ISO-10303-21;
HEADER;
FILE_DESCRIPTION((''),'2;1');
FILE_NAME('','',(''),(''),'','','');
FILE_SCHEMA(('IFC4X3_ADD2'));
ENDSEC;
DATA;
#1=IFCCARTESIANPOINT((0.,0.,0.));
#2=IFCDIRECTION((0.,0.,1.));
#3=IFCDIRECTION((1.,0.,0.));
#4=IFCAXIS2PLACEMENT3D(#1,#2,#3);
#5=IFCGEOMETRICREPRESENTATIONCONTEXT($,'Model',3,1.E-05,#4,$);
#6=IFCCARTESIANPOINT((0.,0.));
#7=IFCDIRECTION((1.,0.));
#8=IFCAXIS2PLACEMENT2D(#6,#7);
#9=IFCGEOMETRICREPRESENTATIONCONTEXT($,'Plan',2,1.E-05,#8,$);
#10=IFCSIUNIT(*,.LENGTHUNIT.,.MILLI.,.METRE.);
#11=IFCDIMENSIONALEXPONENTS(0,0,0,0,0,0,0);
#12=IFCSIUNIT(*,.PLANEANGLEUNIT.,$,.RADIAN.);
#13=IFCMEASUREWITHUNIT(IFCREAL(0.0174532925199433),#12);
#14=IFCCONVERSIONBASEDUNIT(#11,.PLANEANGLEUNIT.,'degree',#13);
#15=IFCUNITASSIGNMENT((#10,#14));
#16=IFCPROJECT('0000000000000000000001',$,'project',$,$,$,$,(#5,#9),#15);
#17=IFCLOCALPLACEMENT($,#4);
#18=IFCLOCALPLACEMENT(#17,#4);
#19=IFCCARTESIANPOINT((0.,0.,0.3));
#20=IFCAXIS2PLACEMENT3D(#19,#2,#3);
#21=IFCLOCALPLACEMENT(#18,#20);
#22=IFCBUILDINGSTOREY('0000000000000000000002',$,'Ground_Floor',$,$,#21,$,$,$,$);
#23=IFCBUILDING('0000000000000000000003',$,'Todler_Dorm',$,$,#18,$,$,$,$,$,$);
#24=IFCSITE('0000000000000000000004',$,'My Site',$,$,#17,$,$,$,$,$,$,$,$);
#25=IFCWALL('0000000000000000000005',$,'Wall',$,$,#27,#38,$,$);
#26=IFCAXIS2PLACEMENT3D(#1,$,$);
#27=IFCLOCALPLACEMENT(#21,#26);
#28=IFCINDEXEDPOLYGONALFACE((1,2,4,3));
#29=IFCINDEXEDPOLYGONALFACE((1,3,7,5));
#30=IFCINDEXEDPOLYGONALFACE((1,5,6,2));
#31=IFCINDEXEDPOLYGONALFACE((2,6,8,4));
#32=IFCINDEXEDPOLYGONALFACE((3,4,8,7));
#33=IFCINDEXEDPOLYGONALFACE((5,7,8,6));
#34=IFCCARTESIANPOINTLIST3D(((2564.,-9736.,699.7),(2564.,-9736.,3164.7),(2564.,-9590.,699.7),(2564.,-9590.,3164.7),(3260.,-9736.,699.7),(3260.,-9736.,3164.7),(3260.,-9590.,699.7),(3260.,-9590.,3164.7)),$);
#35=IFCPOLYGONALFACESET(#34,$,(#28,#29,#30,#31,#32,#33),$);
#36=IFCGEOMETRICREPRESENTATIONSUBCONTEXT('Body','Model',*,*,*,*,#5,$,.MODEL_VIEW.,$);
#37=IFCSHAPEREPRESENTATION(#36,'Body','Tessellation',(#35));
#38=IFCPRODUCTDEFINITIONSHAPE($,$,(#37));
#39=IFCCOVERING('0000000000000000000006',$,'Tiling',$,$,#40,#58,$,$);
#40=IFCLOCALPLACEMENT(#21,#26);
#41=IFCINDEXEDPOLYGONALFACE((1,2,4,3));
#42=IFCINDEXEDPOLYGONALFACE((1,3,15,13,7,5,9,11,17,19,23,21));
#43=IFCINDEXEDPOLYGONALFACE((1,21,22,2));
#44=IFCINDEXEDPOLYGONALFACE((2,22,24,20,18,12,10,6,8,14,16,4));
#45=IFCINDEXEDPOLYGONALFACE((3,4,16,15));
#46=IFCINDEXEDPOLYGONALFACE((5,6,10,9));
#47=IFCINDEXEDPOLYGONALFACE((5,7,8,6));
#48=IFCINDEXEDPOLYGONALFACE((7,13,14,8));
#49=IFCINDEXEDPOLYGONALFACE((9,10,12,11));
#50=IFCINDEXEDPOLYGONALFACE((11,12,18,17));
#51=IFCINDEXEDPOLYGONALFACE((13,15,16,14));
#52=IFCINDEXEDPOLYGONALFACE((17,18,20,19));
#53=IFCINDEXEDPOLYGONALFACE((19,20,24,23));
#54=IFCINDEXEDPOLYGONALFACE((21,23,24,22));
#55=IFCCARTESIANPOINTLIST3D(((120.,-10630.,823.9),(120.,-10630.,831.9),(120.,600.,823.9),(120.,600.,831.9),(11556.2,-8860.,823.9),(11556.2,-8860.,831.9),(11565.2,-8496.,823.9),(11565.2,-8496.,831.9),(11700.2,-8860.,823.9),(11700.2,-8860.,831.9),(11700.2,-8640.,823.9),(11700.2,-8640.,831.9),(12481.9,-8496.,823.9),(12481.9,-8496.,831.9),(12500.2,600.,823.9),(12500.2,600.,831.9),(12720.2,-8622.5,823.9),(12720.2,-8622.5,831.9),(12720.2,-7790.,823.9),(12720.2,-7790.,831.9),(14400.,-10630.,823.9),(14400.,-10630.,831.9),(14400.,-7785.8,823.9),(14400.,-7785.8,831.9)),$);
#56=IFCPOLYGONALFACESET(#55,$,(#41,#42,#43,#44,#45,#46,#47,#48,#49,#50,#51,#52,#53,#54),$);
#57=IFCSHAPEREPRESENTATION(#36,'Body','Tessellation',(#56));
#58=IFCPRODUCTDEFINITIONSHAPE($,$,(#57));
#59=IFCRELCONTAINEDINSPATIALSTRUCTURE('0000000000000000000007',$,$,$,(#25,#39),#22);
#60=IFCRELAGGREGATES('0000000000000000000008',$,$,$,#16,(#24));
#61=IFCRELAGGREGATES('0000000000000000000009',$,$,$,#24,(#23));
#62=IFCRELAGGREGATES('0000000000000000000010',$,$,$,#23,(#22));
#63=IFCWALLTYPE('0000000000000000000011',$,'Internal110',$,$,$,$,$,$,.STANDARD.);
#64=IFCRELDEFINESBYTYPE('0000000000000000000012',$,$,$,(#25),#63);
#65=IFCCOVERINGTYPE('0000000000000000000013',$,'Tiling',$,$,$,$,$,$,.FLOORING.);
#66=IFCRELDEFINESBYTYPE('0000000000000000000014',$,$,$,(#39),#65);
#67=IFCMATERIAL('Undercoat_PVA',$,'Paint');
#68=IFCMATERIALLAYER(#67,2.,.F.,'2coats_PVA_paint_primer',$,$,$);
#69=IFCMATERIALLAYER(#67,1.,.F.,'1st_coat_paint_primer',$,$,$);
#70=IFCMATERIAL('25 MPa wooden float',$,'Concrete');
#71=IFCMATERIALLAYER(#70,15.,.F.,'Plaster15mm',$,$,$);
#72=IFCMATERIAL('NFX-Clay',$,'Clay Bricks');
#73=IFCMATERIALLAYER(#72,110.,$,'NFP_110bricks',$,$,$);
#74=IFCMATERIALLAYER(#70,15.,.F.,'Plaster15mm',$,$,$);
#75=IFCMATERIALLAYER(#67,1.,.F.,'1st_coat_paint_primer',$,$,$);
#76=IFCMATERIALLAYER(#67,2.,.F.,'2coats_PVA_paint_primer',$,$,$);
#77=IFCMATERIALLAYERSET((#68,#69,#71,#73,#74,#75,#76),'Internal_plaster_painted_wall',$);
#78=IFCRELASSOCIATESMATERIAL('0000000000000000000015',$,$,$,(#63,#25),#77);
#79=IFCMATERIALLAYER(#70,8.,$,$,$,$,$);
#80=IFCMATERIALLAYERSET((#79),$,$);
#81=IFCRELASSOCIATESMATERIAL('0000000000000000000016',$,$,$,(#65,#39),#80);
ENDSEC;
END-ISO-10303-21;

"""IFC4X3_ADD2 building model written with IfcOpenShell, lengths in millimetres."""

from ifc_helpers import new_model, entity, si_unit, converted_unit, frame, origin_with_axes, origin_2d_with_axis, place, context, subcontext, project, spatial, line, indexed_curve, outline, extrude, material, layer, layer_set, layer_usage, type_object, element, save


model = new_model("IFC4X3_ADD2")

# Units and contexts
model_context = context("Model", 3, precision=1e-05, world=origin_with_axes())
plan_context = context("Plan", 2, precision=1e-05, world=origin_2d_with_axis())
body_context_1 = subcontext(model_context, "Body", "Model", "MODEL_VIEW")
ifc_project = project(units=[si_unit("LENGTHUNIT", "METRE", prefix="MILLI"), converted_unit("PLANEANGLEUNIT", "degree", entity("IfcReal", 0.0174532925199433), si_unit("PLANEANGLEUNIT", "RADIAN"), dimensions=[0, 0, 0, 0, 0, 0, 0])], contexts=[model_context, plan_context])

# Site, building, storey
site_placement = place(None, origin_with_axes())
site = spatial("IfcSite", under=ifc_project, at=site_placement, Name="My Site")
building_placement = place(site_placement, origin_with_axes())
building = spatial("IfcBuilding", under=site, at=building_placement, Name="Todler_Dorm")
storey_placement = place(building_placement, frame((0.0, 0.0, 0.3), z_axis=(0.0, 0.0, 1.0), x_axis=(1.0, 0.0, 0.0)))
storey = spatial("IfcBuildingStorey", under=building, at=storey_placement, Name="Ground_Floor")

# Shared definitions
ifc_material_1 = material(Name="Undercoat_PVA", Category="Paint")
ifc_layer_1 = layer(ifc_material_1, 2.0, ventilated=False, Name="2coats_PVA_paint_primer")
ifc_layer_2 = layer(ifc_material_1, 1.0, ventilated=False, Name="1st_coat_paint_primer")
ifc_material_2 = material(Name="25 MPa wooden float", Category="Concrete")
ifc_layer_3 = layer(ifc_material_2, 15.0, ventilated=False, Name="Plaster15mm")
ifc_material_3 = material(Name="NFX-Clay", Category="Clay Bricks")
ifc_layer_4 = layer(ifc_material_3, 110.0, Name="NFP_110bricks")
ifc_layer_5 = layer(ifc_material_2, 15.0, ventilated=False, Name="Plaster15mm")
ifc_layer_6 = layer(ifc_material_1, 1.0, ventilated=False, Name="1st_coat_paint_primer")
ifc_layer_7 = layer(ifc_material_1, 2.0, ventilated=False, Name="2coats_PVA_paint_primer")
ifc_layer_set_1 = layer_set([ifc_layer_1, ifc_layer_2, ifc_layer_3, ifc_layer_4, ifc_layer_5, ifc_layer_6, ifc_layer_7], Name="Internal_plaster_painted_wall")
wall_type_1 = type_object("IfcWallType", Name="Internal110", PredefinedType="STANDARD", material=ifc_layer_set_1)

# Wall
ifc_layer_usage_1 = layer_usage(ifc_layer_set_1, "AXIS2", "POSITIVE", 0.0)
wall_1_placement = place(storey_placement, frame((3260.0, -9590.0, 699.7), z_axis=(0.0, 0.0, 1.0), x_axis=(-1.0, 0.0, 0.0)))
element("IfcWall", 1, at=wall_1_placement, inside=storey, type_object=wall_type_1, material=ifc_layer_usage_1, Name="Wall", context=body_context_1, shape_type="SweptSolid", body=[
    extrude(outline(indexed_curve([(0.0, 0.0), (0.0, 146.0), (696.0, 146.0), (696.0, 0.0)], segments=[line(1, 2, 3, 4, 1)])), origin_with_axes(), (0.0, 0.0, 1.0), 2465.0),
])

# Covering
ifc_layer_8 = layer(ifc_material_2, 8.0)
ifc_layer_set_2 = layer_set([ifc_layer_8])
ifc_layer_usage_2 = layer_usage(ifc_layer_set_2, "AXIS3", "POSITIVE", -100.0)
covering_type = type_object("IfcCoveringType", Name="Tiling", PredefinedType="FLOORING", material=ifc_layer_set_2)
covering_placement = place(storey_placement, frame((120.0, -10630.0, 923.9), z_axis=(0.0, 0.0, 1.0), x_axis=(1.0, 0.0, 0.0)))
element("IfcCovering", 2, at=covering_placement, inside=storey, type_object=covering_type, material=ifc_layer_usage_2, Name="Tiling", context=body_context_1, shape_type="SweptSolid", body=[
    extrude(outline(indexed_curve([(11580.2, 1770.0), (11580.2, 1990.0), (12600.2, 2007.5), (12600.2, 2840.0), (14280.0, 2844.3), (14280.0, 0.0), (0.0, 0.0), (0.0, 11230.0), (12380.2, 11230.0), (12361.9, 2134.0), (11445.2, 2134.0), (11436.2, 1770.0), (11580.2, 1770.0)])), frame((0.0, 0.0, -100.0), z_axis=(0.0, 0.0, 1.0), x_axis=(1.0, 0.0, 0.0)), (0.0, 0.0, 1.0), 8.0),
])

save(model, "model.ifc")
